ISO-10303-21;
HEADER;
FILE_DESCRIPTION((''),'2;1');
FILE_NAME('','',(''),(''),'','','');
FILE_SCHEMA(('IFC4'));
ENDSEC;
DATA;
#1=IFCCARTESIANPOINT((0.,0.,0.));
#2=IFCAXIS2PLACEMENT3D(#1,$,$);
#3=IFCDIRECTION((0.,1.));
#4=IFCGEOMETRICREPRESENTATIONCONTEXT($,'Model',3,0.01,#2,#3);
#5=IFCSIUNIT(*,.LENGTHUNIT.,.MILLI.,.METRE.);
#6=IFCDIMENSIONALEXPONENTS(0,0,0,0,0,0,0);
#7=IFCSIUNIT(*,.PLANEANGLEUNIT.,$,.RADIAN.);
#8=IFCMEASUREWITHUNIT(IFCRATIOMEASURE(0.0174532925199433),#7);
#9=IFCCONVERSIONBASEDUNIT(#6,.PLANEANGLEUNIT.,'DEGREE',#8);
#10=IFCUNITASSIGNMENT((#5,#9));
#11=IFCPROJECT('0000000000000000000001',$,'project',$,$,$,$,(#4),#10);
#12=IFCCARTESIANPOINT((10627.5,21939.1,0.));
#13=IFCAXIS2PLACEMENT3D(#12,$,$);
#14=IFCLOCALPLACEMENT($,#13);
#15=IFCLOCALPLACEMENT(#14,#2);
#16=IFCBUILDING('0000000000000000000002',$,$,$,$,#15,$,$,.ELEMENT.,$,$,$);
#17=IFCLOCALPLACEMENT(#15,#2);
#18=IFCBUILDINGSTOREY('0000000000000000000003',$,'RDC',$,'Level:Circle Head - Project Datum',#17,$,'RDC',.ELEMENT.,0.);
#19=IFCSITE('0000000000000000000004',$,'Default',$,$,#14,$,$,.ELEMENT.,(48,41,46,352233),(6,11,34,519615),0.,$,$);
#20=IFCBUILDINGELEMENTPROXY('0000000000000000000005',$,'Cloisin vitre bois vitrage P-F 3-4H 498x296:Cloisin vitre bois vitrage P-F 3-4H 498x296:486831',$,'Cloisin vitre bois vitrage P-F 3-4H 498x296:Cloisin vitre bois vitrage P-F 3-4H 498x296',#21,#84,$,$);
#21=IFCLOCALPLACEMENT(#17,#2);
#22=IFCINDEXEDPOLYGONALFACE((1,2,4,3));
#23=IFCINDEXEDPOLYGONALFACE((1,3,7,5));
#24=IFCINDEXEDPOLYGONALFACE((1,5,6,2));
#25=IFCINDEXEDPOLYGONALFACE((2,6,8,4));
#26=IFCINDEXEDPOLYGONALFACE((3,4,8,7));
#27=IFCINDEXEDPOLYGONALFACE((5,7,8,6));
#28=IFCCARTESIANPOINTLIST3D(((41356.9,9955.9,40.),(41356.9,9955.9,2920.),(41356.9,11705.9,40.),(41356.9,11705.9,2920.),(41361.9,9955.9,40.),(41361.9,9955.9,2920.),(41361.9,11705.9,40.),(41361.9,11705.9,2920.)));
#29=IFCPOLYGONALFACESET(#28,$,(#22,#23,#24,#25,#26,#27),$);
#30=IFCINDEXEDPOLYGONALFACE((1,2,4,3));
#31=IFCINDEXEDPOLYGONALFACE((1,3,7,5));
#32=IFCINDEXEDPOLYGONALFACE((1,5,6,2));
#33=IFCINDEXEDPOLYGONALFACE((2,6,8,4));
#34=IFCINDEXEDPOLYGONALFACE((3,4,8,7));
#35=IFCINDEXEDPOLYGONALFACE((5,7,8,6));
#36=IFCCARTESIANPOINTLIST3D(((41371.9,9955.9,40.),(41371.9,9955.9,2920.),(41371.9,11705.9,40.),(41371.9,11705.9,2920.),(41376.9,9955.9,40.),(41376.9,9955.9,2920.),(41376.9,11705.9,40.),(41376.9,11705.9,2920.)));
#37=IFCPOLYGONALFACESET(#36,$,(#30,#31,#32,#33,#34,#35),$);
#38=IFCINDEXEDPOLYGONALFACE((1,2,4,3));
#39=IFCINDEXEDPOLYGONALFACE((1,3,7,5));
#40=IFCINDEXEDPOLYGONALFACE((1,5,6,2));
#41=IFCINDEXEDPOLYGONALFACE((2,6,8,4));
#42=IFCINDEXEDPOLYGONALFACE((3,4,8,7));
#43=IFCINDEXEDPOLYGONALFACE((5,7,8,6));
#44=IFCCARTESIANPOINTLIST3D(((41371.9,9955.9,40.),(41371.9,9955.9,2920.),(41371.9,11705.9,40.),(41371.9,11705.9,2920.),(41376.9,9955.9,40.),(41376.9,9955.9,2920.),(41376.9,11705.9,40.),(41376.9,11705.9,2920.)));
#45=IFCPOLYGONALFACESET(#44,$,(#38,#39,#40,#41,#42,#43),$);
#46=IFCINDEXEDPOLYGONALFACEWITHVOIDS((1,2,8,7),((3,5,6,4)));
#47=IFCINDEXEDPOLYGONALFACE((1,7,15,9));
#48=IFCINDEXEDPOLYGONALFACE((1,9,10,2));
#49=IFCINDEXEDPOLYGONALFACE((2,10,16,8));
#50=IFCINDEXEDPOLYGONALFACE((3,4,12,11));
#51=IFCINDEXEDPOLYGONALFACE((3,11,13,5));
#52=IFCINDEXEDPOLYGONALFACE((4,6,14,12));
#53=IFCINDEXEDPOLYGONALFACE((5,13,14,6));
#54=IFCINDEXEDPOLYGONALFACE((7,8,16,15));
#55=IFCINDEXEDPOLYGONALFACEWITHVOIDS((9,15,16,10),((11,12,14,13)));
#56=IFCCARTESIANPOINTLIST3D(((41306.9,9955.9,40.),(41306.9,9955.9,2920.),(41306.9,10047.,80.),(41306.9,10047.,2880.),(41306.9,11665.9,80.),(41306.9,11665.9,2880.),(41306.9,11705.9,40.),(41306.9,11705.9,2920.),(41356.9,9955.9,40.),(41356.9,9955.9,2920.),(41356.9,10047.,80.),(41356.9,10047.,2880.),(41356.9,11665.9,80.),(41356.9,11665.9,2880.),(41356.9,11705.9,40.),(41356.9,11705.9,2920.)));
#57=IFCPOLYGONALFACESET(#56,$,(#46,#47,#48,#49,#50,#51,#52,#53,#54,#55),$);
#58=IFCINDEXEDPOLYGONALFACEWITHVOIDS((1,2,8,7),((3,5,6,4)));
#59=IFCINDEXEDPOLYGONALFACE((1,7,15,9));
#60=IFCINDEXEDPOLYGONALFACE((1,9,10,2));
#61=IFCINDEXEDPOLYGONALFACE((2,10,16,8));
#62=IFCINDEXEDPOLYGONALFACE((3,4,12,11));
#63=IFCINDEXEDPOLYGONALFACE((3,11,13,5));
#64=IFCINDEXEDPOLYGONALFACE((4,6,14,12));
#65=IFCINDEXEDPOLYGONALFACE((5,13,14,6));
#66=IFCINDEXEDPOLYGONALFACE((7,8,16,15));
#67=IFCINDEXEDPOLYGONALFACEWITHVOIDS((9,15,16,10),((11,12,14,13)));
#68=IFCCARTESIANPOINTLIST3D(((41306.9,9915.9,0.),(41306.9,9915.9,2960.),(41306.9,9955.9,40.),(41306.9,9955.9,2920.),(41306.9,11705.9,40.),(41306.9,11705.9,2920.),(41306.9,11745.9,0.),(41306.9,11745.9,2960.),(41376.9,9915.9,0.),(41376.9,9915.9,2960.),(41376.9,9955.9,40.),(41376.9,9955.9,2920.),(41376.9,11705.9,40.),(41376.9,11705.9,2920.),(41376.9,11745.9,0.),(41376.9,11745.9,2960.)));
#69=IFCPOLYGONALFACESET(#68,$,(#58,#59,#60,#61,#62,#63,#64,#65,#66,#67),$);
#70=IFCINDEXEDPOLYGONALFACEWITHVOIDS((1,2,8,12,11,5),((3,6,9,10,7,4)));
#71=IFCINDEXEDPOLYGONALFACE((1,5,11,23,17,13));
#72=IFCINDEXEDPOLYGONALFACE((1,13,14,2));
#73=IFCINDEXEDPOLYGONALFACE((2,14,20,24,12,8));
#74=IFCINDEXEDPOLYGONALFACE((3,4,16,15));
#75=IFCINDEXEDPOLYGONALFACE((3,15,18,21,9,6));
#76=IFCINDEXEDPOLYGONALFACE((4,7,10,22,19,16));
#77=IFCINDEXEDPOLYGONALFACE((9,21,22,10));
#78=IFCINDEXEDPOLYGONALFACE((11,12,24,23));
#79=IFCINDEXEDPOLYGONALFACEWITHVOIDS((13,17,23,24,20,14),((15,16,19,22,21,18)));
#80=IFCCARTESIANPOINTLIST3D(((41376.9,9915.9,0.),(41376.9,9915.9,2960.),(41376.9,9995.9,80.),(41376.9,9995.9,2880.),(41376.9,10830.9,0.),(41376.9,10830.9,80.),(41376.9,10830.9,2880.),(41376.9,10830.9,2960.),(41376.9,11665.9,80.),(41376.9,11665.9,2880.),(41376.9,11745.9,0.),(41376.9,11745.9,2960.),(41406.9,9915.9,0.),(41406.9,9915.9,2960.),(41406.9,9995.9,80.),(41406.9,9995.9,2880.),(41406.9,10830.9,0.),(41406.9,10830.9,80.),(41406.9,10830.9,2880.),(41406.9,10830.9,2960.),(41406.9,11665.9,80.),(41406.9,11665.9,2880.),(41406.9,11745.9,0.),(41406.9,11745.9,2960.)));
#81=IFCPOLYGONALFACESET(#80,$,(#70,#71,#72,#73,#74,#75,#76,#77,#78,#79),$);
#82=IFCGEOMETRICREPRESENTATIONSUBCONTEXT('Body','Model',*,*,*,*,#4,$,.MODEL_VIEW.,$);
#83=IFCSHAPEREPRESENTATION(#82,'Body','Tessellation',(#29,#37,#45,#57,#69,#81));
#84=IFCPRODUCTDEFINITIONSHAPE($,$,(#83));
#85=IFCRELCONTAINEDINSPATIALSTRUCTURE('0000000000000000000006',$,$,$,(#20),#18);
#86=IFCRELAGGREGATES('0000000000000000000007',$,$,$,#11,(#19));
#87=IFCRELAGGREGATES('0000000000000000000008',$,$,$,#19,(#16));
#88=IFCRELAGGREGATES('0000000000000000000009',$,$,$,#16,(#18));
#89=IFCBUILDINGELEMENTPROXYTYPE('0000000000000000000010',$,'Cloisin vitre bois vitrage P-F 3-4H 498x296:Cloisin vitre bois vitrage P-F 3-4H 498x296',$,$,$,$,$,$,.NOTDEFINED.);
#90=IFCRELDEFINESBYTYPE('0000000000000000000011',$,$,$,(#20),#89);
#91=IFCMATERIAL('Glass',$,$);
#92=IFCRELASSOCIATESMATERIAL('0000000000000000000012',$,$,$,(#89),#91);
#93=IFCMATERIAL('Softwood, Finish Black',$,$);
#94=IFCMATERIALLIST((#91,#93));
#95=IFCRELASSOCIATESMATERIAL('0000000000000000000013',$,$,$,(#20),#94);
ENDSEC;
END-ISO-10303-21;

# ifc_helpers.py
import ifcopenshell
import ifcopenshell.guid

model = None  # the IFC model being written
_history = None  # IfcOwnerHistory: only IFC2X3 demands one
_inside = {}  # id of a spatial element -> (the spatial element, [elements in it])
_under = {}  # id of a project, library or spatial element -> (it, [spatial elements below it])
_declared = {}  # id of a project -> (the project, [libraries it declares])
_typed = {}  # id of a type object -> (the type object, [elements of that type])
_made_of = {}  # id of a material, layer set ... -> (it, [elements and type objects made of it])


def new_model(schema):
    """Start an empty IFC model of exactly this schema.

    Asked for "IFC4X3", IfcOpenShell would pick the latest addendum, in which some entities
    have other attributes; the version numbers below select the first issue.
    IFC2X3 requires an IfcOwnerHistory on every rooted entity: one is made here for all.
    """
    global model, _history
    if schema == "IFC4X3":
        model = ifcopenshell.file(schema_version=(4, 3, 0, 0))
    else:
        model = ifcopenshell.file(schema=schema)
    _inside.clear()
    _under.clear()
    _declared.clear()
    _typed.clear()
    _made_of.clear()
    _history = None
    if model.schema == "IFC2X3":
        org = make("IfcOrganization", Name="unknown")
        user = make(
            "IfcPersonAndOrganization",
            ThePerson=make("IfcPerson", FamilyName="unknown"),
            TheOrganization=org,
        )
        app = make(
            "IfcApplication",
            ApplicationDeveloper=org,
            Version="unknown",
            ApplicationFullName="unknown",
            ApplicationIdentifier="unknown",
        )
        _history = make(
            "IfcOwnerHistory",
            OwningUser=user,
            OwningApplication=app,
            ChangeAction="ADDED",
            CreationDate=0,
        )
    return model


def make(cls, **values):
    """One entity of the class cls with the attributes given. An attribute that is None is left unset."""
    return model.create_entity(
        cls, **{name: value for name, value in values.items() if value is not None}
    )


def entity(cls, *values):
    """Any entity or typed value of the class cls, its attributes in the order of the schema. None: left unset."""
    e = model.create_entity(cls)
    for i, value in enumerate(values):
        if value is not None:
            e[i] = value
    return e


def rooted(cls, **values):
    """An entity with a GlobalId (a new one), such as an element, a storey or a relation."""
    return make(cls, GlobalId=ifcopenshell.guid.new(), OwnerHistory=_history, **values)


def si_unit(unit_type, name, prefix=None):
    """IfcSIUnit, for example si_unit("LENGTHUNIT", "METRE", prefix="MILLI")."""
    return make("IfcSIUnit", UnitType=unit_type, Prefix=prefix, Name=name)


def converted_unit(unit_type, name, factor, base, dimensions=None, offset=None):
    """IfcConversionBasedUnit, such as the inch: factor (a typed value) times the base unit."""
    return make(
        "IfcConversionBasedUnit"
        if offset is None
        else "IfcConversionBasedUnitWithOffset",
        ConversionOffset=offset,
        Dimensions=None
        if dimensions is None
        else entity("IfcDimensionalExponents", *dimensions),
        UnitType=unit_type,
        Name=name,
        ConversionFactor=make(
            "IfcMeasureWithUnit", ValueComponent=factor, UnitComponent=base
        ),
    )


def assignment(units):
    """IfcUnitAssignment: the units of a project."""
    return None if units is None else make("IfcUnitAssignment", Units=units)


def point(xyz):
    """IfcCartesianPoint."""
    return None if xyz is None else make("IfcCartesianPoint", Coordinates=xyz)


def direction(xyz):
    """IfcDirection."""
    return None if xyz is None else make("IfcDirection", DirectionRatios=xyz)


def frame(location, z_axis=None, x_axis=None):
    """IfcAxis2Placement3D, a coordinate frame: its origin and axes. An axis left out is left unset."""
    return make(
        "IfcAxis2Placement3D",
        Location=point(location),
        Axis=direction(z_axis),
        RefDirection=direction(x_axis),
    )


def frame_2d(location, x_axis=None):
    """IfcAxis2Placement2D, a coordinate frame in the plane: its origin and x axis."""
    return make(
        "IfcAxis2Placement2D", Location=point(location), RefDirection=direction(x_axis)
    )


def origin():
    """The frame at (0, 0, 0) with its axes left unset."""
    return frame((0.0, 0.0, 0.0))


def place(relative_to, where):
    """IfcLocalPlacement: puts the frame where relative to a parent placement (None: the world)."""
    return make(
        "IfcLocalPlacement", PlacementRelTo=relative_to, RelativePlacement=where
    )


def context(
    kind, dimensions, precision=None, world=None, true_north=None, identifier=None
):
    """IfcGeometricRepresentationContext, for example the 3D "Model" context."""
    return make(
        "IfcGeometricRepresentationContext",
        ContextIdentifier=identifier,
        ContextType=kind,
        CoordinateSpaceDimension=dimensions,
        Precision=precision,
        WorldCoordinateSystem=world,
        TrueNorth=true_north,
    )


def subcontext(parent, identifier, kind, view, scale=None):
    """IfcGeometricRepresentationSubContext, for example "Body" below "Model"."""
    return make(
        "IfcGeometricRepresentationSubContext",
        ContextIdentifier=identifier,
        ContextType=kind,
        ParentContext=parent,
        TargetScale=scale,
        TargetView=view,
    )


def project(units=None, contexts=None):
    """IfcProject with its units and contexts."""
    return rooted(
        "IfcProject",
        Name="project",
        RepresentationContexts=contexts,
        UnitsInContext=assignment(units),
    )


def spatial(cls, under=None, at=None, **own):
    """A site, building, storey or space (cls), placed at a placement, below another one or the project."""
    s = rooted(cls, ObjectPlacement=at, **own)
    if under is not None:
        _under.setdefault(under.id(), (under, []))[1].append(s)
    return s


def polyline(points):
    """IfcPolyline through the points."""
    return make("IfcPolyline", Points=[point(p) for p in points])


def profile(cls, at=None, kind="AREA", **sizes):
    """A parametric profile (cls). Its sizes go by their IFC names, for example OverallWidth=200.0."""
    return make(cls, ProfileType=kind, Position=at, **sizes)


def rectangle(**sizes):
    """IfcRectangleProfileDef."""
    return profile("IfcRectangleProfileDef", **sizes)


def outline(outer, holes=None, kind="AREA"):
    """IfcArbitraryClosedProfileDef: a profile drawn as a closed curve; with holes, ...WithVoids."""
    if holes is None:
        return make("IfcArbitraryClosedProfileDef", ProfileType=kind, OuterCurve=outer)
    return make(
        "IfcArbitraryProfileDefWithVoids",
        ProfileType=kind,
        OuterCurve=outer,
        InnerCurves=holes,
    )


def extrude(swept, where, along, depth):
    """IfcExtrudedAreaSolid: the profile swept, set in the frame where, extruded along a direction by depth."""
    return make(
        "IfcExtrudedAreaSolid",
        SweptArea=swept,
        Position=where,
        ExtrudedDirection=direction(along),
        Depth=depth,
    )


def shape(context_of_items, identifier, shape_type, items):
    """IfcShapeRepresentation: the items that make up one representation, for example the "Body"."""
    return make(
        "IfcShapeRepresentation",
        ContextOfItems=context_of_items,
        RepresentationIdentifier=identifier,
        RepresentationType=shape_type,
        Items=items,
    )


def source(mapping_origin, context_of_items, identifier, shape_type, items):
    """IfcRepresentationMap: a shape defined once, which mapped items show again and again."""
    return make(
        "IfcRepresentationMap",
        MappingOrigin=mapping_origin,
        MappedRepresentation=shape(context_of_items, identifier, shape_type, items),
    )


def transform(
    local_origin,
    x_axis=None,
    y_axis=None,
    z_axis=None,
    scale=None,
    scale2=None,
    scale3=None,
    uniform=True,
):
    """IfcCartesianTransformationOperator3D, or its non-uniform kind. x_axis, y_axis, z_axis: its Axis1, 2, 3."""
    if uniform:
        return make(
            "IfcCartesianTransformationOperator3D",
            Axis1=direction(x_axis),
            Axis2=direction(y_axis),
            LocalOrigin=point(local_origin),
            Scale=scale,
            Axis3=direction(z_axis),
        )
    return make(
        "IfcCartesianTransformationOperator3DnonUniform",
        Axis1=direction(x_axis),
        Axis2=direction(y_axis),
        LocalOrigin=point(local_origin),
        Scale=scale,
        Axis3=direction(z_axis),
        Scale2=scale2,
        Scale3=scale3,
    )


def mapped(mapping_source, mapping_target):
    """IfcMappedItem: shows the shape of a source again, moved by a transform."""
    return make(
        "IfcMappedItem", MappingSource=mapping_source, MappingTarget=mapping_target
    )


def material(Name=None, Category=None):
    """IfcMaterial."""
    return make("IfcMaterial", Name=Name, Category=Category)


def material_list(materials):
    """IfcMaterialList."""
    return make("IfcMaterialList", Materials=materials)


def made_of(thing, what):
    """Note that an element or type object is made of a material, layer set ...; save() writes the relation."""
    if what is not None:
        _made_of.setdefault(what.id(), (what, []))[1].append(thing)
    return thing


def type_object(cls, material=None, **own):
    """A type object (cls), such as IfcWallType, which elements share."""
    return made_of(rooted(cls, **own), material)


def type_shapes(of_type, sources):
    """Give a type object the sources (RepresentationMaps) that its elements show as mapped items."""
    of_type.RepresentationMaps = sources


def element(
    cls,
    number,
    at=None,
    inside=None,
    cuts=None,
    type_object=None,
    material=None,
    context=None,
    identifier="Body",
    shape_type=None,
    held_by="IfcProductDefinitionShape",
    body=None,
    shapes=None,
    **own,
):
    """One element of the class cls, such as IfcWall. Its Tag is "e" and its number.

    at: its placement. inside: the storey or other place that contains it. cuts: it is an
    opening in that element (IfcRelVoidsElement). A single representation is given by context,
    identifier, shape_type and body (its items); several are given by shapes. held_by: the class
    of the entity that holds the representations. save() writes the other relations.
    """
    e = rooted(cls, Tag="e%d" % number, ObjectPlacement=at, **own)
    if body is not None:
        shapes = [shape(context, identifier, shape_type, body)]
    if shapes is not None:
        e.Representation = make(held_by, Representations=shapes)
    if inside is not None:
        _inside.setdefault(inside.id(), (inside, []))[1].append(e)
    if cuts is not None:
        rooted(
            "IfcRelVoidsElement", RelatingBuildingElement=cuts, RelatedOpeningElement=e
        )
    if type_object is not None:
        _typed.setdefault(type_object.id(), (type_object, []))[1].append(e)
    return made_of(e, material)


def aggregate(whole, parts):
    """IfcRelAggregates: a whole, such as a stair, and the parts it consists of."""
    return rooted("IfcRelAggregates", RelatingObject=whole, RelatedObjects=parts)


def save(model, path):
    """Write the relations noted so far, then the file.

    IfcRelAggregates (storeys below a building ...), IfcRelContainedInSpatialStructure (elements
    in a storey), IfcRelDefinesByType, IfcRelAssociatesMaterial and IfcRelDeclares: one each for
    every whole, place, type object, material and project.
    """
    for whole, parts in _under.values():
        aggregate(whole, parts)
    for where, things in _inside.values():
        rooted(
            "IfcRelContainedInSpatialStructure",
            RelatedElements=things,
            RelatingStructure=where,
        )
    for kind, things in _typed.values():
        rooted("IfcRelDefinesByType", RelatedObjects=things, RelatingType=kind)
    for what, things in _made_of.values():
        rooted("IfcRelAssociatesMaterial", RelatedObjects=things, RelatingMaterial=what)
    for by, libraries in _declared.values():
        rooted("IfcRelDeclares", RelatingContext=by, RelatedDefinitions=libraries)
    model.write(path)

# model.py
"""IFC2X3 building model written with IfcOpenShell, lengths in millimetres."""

from ifc_helpers import new_model, entity, si_unit, converted_unit, direction, frame, frame_2d, origin, place, context, subcontext, project, spatial, polyline, rectangle, outline, extrude, source, transform, mapped, material, material_list, type_object, type_shapes, element, save


model = new_model("IFC2X3")

# Units and contexts
model_context = context("Model", 3, precision=0.01, world=origin(), true_north=direction((0.0, 1.0)))
body_context = subcontext(model_context, "Body", "Model", "MODEL_VIEW")
ifc_project = project(units=[si_unit("LENGTHUNIT", "METRE", prefix="MILLI"), converted_unit("PLANEANGLEUNIT", "DEGREE", entity("IfcRatioMeasure", 0.0174532925199433), si_unit("PLANEANGLEUNIT", "RADIAN"), dimensions=[0, 0, 0, 0, 0, 0, 0])], contexts=[model_context])

# Site, building, storey
site_placement = place(None, frame((10627.5, 21939.1, 0.0)))
site = spatial("IfcSite", under=ifc_project, at=site_placement, Name="Default", CompositionType="ELEMENT", RefLatitude=(48, 41, 46, 352233), RefLongitude=(6, 11, 34, 519615), RefElevation=0.0)
building_placement = place(site_placement, origin())
building = spatial("IfcBuilding", under=site, at=building_placement, CompositionType="ELEMENT")
storey_placement = place(building_placement, origin())
storey = spatial("IfcBuildingStorey", under=building, at=storey_placement, Name="RDC", ObjectType="Level:Circle Head - Project Datum", LongName="RDC", CompositionType="ELEMENT", Elevation=0.0)

# Shared definitions
ifc_material_1 = material(Name="Glass")

# Building element proxy
ifc_material_2 = material(Name="Softwood, Finish Black")
building_element_proxy_type = type_object("IfcBuildingElementProxyType", Name="Cloisin vitre bois vitrage P-F 3-4H 498x296:Cloisin vitre bois vitrage P-F 3-4H 498x296", PredefinedType="NOTDEFINED", material=ifc_material_1)
shared_shape_1 = source(origin(), body_context, "Body", "SweptSolid", [
    extrude(rectangle(XDim=5.0, YDim=1750.0, at=frame_2d((0.0, 0.0), x_axis=(1.0, 0.0))), frame((0.0, -47.5, 40.0), z_axis=(0.0, 0.0, 1.0), x_axis=(0.0, 1.0, 0.0)), (0.0, 0.0, 1.0), 2880.0),
    extrude(rectangle(XDim=5.0, YDim=1750.0, at=frame_2d((0.0, 0.0), x_axis=(1.0, 0.0))), frame((0.0, -32.5, 40.0), z_axis=(0.0, 0.0, 1.0), x_axis=(0.0, 1.0, 0.0)), (0.0, 0.0, 1.0), 2880.0),
    extrude(rectangle(XDim=5.0, YDim=1750.0, at=frame_2d((0.0, 0.0), x_axis=(1.0, 0.0))), frame((0.0, -32.5, 40.0), z_axis=(0.0, 0.0, 1.0), x_axis=(0.0, 1.0, 0.0)), (0.0, 0.0, 1.0), 2880.0),
    extrude(outline(polyline([(-1440.0, -875.0), (1440.0, -875.0), (1440.0, 875.0), (-1440.0, 875.0), (-1440.0, -875.0)]), holes=[polyline([(1400.0, 835.0), (1400.0, -783.9), (-1400.0, -783.9), (-1400.0, 835.0), (1400.0, 835.0)])]), frame((0.0, -100.0, 1480.0), z_axis=(0.0, 1.0, 0.0), x_axis=(0.0, 0.0, -1.0)), (0.0, 0.0, 1.0), 50.0),
    extrude(outline(polyline([(-1480.0, -915.0), (1480.0, -915.0), (1480.0, 915.0), (-1480.0, 915.0), (-1480.0, -915.0)]), holes=[polyline([(-1440.0, -875.0), (-1440.0, 875.0), (1440.0, 875.0), (1440.0, -875.0), (-1440.0, -875.0)])]), frame((0.0, -100.0, 1480.0), z_axis=(0.0, 1.0, 0.0), x_axis=(0.0, 0.0, -1.0)), (0.0, 0.0, 1.0), 70.0),
    extrude(outline(polyline([(-1480.0, -915.0), (1480.0, -915.0), (1480.0, 0.0), (1480.0, 915.0), (-1480.0, 915.0), (-1480.0, 0.0), (-1480.0, -915.0)]), holes=[polyline([(1400.0, 0.0), (1400.0, -835.0), (-1400.0, -835.0), (-1400.0, 0.0), (-1400.0, 835.0), (1400.0, 835.0), (1400.0, 0.0)])]), frame((0.0, -30.0, 1480.0), z_axis=(0.0, 1.0, 0.0), x_axis=(0.0, 0.0, 1.0)), (0.0, 0.0, 1.0), 30.0),
])
type_shapes(building_element_proxy_type, [shared_shape_1])
ifc_material_list_1 = material_list([ifc_material_1, ifc_material_2])
proxy_1_placement = place(storey_placement, frame((41406.9, 10830.9, 0.0), z_axis=(0.0, 0.0, 1.0), x_axis=(0.0, -1.0, 0.0)))
element("IfcBuildingElementProxy", 1, at=proxy_1_placement, inside=storey, type_object=building_element_proxy_type, material=ifc_material_list_1, Name="Cloisin vitre bois vitrage P-F 3-4H 498x296:Cloisin vitre bois vitrage P-F 3-4H 498x296:486831", ObjectType="Cloisin vitre bois vitrage P-F 3-4H 498x296:Cloisin vitre bois vitrage P-F 3-4H 498x296", context=body_context, shape_type="MappedRepresentation", body=[
    mapped(shared_shape_1, transform((0.0, 0.0, 0.0), scale=1.0)),
])

save(model, "model.ifc")
